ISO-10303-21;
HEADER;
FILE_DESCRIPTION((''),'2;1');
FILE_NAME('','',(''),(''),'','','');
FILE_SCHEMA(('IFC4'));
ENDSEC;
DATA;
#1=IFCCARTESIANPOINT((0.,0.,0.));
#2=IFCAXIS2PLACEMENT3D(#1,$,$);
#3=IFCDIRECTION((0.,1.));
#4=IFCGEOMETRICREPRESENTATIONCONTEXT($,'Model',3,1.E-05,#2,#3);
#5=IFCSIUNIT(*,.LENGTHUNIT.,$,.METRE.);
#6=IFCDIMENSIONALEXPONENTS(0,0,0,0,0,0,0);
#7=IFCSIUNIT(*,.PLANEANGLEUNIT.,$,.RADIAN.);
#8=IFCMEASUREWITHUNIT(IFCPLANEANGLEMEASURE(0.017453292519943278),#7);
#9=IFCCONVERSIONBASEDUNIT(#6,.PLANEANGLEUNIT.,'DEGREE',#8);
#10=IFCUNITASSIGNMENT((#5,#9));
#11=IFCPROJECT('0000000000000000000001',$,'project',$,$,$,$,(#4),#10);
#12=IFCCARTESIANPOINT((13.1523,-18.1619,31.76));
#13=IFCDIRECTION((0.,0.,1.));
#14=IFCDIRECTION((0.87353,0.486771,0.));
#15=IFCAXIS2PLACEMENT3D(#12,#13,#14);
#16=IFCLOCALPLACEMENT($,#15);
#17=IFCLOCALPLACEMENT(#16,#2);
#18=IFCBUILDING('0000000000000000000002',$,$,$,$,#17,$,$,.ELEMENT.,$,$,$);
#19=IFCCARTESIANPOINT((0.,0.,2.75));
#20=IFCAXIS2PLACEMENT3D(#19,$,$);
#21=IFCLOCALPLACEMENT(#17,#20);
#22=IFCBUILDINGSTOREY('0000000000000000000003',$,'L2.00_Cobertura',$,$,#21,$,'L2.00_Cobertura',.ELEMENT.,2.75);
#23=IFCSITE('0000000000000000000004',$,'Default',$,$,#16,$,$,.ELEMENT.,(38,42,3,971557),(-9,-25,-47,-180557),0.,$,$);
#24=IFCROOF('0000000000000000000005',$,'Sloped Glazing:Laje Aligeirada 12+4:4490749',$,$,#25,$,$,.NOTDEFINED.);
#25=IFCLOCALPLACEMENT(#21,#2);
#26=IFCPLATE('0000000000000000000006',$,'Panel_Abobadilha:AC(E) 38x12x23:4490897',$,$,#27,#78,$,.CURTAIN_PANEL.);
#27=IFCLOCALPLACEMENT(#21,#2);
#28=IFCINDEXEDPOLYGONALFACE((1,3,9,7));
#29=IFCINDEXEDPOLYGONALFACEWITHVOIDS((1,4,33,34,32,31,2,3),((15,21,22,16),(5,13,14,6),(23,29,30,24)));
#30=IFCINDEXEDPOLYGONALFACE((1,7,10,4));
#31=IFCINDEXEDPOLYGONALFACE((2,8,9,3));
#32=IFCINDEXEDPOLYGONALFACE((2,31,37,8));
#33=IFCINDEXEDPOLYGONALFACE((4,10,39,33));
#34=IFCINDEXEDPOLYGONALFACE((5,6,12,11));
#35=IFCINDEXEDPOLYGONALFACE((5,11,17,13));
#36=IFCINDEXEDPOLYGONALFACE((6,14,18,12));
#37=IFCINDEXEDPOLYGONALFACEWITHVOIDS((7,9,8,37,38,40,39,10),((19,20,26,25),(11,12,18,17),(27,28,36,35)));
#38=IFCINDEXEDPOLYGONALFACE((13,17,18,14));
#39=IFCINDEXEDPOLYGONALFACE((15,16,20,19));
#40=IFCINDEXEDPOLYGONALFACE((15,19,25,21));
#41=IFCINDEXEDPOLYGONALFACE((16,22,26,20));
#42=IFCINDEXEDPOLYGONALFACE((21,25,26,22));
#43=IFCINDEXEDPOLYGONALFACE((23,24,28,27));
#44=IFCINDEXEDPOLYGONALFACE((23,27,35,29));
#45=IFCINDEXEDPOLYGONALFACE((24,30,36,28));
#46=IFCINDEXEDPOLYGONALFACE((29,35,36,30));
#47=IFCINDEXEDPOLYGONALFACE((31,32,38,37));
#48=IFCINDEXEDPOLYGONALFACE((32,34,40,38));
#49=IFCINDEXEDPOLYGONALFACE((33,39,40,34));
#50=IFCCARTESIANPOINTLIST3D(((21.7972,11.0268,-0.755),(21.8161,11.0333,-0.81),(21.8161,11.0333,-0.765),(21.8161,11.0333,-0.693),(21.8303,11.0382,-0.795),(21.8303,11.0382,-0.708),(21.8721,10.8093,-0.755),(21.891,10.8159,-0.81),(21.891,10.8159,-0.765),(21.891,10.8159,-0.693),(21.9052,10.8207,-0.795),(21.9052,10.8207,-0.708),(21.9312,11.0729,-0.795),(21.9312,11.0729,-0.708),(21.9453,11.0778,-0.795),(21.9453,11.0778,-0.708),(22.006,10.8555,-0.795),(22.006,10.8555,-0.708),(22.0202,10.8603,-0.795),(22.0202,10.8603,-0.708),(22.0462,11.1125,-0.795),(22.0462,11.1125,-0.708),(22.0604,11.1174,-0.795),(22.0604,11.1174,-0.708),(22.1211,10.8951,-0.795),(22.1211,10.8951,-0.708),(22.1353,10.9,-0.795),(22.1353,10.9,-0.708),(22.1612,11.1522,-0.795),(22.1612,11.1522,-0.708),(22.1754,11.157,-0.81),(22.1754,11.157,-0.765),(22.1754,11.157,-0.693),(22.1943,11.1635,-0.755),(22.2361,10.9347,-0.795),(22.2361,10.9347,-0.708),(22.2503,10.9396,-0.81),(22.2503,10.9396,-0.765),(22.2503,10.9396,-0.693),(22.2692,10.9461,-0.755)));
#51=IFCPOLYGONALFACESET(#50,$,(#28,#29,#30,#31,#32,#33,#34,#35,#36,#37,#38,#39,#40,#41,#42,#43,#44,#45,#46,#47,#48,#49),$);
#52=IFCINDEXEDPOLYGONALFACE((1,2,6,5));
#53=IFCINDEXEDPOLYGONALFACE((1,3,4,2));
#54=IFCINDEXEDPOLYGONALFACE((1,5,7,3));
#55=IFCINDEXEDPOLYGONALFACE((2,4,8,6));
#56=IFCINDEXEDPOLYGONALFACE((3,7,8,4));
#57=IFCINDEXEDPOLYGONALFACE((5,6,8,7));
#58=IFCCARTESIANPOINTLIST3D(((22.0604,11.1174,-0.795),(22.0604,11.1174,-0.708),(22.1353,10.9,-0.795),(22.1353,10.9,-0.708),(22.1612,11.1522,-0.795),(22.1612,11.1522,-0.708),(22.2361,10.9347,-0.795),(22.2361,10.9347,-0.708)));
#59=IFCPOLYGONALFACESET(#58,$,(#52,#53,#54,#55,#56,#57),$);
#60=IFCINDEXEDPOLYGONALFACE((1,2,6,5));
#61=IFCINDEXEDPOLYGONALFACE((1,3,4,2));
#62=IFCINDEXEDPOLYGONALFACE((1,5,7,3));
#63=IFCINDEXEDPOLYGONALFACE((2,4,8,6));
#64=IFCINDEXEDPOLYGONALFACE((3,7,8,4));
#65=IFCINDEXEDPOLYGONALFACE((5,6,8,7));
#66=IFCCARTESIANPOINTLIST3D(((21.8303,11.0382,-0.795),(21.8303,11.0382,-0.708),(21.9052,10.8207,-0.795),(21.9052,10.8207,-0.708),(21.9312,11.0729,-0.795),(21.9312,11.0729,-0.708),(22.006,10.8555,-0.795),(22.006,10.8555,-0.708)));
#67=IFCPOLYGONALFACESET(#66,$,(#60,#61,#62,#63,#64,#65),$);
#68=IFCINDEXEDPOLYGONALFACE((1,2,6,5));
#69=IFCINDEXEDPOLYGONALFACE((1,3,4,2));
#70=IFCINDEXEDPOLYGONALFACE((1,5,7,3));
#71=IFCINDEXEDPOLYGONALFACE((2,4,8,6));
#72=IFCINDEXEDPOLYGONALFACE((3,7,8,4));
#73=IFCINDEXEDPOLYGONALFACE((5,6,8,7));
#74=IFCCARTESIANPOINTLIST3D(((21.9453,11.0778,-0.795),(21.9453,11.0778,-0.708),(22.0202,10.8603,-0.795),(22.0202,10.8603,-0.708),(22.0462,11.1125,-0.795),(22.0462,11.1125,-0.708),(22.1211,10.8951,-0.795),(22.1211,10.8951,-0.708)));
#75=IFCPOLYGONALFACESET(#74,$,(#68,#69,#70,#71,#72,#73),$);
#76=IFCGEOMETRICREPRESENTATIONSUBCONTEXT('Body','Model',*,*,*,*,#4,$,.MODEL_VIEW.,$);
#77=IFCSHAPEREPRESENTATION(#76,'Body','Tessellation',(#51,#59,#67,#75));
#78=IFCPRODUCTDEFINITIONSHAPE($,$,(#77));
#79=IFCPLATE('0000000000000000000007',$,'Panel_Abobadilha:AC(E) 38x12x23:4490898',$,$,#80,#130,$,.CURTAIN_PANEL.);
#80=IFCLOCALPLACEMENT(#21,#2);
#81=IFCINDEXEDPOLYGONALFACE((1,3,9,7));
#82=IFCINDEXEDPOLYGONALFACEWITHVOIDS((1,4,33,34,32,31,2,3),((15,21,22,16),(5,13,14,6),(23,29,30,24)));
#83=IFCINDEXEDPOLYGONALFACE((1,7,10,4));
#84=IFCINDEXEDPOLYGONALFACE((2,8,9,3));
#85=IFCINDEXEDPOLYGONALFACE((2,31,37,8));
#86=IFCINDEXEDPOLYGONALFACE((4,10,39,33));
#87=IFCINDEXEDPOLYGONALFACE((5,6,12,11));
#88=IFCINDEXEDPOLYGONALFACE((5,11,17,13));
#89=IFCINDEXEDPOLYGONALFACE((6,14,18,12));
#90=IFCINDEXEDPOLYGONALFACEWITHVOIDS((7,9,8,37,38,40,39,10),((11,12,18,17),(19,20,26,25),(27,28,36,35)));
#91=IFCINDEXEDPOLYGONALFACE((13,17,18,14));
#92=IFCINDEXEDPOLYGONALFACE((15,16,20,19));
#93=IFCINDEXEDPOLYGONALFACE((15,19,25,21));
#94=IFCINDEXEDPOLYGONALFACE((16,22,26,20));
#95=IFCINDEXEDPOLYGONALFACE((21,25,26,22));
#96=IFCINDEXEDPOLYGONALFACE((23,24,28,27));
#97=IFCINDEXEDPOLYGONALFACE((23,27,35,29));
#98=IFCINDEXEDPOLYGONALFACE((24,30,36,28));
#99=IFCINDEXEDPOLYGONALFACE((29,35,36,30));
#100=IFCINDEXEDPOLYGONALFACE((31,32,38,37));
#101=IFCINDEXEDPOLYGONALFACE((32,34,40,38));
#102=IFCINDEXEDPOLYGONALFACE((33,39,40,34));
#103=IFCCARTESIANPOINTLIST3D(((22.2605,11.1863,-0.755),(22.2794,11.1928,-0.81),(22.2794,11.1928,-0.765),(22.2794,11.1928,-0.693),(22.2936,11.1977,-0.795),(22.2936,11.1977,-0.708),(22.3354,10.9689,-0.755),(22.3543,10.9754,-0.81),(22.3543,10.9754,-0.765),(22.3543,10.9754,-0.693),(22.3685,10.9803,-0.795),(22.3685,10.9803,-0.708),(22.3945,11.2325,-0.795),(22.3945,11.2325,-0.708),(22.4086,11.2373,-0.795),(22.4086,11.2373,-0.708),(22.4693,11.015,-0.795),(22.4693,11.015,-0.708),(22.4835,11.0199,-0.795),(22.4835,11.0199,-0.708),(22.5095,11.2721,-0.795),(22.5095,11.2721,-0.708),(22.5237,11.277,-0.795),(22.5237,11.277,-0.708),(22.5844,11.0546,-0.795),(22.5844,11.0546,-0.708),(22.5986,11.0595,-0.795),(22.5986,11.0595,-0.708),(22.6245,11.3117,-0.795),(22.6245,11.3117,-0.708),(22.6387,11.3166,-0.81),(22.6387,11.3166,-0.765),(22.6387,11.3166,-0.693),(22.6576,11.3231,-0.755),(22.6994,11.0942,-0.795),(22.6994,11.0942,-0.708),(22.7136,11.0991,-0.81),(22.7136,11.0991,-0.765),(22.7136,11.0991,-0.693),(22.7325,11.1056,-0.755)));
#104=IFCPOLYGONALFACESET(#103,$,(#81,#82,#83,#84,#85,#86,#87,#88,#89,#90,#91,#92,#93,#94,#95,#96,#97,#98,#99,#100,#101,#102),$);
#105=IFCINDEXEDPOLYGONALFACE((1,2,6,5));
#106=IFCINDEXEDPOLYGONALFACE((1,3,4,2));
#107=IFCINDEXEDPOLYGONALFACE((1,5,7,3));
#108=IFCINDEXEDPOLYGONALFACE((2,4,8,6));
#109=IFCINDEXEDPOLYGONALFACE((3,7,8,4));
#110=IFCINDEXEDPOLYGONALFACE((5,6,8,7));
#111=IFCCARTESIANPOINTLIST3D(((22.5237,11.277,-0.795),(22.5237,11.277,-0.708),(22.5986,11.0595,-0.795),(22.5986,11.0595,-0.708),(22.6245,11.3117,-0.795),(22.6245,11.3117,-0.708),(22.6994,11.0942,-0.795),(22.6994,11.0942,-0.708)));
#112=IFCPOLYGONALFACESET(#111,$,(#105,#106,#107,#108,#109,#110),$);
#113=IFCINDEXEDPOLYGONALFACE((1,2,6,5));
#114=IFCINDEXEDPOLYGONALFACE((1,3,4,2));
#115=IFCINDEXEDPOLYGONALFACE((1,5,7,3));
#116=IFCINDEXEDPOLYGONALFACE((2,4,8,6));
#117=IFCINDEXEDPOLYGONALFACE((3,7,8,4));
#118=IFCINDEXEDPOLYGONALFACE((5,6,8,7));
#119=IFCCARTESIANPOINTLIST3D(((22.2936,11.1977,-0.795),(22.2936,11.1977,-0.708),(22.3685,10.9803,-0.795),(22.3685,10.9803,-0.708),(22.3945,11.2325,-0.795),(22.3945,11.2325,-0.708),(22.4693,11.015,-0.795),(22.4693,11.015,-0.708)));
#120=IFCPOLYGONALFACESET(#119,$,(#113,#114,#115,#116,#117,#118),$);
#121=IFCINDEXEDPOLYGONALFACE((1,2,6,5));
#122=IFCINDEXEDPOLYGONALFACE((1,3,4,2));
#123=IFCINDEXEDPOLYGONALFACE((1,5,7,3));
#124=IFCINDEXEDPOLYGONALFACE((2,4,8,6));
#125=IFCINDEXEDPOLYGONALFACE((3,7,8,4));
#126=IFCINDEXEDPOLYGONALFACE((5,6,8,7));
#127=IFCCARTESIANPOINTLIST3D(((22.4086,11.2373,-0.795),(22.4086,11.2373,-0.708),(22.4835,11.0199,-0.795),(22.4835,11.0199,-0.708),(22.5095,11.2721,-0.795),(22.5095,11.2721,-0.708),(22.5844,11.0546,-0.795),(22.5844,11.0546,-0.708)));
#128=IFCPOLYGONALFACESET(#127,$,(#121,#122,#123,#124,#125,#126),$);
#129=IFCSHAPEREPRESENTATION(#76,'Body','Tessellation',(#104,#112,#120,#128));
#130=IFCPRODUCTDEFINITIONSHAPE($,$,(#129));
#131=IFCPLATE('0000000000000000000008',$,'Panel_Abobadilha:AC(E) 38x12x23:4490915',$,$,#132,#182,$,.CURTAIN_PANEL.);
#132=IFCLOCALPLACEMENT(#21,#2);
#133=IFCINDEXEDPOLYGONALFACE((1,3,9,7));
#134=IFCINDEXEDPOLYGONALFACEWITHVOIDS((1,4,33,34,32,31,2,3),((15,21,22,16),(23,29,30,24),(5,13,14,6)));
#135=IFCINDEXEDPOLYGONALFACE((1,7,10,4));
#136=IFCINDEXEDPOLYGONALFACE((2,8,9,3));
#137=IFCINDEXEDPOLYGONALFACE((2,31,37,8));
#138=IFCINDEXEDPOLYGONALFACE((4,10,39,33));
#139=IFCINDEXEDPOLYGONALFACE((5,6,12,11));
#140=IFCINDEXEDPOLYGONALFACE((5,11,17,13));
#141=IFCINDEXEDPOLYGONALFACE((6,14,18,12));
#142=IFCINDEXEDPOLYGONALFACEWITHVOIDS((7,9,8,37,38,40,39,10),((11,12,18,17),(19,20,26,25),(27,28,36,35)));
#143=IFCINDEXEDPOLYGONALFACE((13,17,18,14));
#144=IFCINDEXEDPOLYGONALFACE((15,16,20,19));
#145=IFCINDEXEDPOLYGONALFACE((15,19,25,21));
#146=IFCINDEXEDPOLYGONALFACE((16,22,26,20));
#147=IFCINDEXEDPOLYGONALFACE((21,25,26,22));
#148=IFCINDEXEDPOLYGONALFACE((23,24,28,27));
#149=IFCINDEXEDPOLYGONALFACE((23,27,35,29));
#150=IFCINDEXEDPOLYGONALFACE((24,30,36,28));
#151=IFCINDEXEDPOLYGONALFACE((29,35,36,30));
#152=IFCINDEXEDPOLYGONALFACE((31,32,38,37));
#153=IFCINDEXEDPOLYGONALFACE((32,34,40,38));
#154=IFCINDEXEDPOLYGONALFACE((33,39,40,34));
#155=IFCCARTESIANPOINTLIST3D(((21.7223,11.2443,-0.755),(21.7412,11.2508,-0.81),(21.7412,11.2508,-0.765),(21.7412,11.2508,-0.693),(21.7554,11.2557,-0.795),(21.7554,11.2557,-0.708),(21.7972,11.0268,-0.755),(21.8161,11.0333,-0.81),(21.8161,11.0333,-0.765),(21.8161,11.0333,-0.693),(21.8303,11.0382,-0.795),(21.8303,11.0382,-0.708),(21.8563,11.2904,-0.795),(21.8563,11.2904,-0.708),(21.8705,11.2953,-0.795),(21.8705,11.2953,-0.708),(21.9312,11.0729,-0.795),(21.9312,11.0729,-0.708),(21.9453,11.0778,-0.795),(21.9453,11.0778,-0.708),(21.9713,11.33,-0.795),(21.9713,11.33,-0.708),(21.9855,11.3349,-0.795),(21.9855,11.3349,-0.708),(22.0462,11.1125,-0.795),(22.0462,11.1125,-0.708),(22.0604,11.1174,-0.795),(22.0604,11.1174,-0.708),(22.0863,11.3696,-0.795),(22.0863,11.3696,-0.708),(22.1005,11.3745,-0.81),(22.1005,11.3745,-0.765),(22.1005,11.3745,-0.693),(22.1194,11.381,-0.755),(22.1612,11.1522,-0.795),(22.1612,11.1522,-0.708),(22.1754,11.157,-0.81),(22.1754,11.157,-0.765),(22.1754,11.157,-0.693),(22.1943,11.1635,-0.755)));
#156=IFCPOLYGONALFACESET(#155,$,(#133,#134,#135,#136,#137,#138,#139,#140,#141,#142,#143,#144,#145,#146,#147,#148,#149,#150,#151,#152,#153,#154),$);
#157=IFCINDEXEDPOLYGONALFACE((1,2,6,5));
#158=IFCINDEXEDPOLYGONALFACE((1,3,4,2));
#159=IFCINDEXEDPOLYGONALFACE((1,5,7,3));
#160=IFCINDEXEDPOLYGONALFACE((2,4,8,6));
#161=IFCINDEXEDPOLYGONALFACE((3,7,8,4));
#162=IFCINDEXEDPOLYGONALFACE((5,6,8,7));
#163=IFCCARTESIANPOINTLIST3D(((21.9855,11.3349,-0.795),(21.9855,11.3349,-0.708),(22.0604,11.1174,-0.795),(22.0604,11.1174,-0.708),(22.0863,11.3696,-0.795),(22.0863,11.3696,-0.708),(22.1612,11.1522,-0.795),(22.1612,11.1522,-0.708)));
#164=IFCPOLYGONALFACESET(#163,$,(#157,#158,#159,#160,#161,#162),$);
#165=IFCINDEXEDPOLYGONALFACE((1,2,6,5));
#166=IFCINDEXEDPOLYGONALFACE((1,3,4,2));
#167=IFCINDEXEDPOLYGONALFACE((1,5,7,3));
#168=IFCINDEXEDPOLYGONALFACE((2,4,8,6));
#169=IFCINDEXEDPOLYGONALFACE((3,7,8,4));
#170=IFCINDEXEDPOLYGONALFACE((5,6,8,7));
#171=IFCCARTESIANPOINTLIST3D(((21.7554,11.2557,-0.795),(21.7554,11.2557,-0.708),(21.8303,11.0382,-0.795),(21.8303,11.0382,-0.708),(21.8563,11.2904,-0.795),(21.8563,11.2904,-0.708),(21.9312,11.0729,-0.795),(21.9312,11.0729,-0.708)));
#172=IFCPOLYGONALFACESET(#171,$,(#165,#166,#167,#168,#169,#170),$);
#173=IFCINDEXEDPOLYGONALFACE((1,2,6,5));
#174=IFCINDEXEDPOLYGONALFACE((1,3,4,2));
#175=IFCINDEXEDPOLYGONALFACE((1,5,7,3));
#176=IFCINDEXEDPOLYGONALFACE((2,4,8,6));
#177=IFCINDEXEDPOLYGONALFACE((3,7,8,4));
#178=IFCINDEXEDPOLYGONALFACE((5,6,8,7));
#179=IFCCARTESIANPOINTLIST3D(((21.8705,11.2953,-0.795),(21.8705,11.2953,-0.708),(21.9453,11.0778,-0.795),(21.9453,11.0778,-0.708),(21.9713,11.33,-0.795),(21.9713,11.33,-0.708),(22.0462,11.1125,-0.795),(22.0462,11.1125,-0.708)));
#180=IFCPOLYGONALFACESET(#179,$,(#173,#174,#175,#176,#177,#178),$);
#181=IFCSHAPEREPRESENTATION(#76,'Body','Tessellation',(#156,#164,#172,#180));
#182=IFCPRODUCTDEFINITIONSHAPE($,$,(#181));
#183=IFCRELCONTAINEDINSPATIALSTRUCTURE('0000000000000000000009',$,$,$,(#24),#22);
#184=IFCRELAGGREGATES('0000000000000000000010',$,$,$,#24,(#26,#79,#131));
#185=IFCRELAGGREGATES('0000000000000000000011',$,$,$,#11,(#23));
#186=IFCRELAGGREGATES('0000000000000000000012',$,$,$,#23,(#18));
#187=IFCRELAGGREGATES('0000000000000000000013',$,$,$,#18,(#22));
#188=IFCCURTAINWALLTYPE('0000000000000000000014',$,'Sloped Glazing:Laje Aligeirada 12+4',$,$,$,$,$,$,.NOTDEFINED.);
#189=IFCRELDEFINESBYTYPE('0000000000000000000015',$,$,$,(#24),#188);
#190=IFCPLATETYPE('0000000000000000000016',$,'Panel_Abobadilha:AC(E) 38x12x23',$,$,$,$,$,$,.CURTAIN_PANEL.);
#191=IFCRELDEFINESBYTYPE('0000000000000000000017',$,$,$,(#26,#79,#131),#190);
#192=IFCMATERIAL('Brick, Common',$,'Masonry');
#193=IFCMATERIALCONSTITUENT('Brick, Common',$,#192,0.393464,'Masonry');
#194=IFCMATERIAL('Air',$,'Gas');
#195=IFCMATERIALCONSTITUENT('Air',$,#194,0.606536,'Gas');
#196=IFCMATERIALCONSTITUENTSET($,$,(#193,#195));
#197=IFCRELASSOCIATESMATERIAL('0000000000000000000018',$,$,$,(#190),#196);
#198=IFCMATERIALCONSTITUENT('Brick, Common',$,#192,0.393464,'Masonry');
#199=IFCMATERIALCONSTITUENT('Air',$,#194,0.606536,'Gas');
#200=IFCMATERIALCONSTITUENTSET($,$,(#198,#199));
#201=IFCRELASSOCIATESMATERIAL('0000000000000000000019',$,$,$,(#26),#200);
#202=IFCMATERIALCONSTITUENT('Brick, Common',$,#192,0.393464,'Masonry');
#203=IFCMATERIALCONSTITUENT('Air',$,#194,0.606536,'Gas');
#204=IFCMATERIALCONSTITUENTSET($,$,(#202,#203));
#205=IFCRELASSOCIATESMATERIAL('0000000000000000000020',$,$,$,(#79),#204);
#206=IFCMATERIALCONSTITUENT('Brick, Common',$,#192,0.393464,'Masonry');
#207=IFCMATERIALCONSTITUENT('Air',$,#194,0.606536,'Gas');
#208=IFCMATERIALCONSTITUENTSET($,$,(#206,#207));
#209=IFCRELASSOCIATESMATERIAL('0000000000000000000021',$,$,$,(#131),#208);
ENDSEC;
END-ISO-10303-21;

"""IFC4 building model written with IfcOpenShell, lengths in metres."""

from ifc_helpers import new_model, entity, si_unit, converted_unit, direction, frame, origin, place, context, subcontext, project, spatial, indexed_curve, outline, extrude, source, transform, mapped, material, constituent, constituent_set, type_object, type_shapes, element, aggregate, save


model = new_model("IFC4")

# Units and contexts
model_context = context("Model", 3, precision=1e-05, world=origin(), true_north=direction((0.0, 1.0)))
body_context = subcontext(model_context, "Body", "Model", "MODEL_VIEW")
ifc_project = project(units=[si_unit("LENGTHUNIT", "METRE"), converted_unit("PLANEANGLEUNIT", "DEGREE", entity("IfcPlaneAngleMeasure", 0.017453292519943278), si_unit("PLANEANGLEUNIT", "RADIAN"), dimensions=[0, 0, 0, 0, 0, 0, 0])], contexts=[model_context])

# Site, building, storey
site_placement = place(None, frame((13.1523, -18.1619, 31.76), z_axis=(0.0, 0.0, 1.0), x_axis=(0.87353, 0.486771, 0.0)))
site = spatial("IfcSite", under=ifc_project, at=site_placement, Name="Default", CompositionType="ELEMENT", RefLatitude=(38, 42, 3, 971557), RefLongitude=(-9, -25, -47, -180557), RefElevation=0.0)
building_placement = place(site_placement, origin())
building = spatial("IfcBuilding", under=site, at=building_placement, CompositionType="ELEMENT")
storey_placement = place(building_placement, frame((0.0, 0.0, 2.75)))
storey = spatial("IfcBuildingStorey", under=building, at=storey_placement, Name="L2.00_Cobertura", LongName="L2.00_Cobertura", CompositionType="ELEMENT", Elevation=2.75)

# Roof
curtain_wall_type = type_object("IfcCurtainWallType", Name="Sloped Glazing:Laje Aligeirada 12+4", PredefinedType="NOTDEFINED")
roof_placement = place(storey_placement, frame((0.0, 0.0, -2.75)))
roof = element("IfcRoof", 1, at=roof_placement, inside=storey, type_object=curtain_wall_type, Name="Sloped Glazing:Laje Aligeirada 12+4:4490749", PredefinedType="NOTDEFINED")

# Plates
ifc_material_1 = material(Name="Brick, Common", Category="Masonry")
ifc_material_2 = material(Name="Air", Category="Gas")
ifc_constituent_1 = constituent(ifc_material_1, Name="Brick, Common", Category="Masonry", fraction=0.393464)
ifc_constituent_2 = constituent(ifc_material_2, Name="Air", Category="Gas", fraction=0.606536)
ifc_constituent_set_1 = constituent_set(constituents=[ifc_constituent_1, ifc_constituent_2])
plate_type_1 = type_object("IfcPlateType", Name="Panel_Abobadilha:AC(E) 38x12x23", PredefinedType="CURTAIN_PANEL", material=ifc_constituent_set_1)
shared_shape_1 = source(origin(), body_context, "Body", "SweptSolid", [
    extrude(outline(indexed_curve([(-0.19, -0.0543), (0.19, -0.0543), (0.19, -0.0093), (0.21, 0.0007), (0.19, 0.0628), (-0.19, 0.0628), (-0.21, 0.0007), (-0.19, -0.0093), (-0.19, -0.0543)], self_intersect=False), holes=[indexed_curve([(-0.0683, 0.0477), (-0.0683, -0.0393), (-0.175, -0.0393), (-0.175, 0.0477), (-0.0683, 0.0477)], self_intersect=False), indexed_curve([(0.0533, 0.0477), (0.0533, -0.0393), (-0.0533, -0.0393), (-0.0533, 0.0477), (0.0533, 0.0477)], self_intersect=False), indexed_curve([(0.175, 0.0477), (0.175, -0.0393), (0.0683, -0.0393), (0.0683, 0.0477), (0.175, 0.0477)], self_intersect=False)]), frame((0.0, 0.0543, 0.0)), (0.0, 0.0, 1.0), 0.23),
    extrude(outline(indexed_curve([(-0.0533, -0.0435), (0.0533, -0.0435), (0.0533, 0.0435), (-0.0533, 0.0435), (-0.0533, -0.0435)], self_intersect=False)), frame((0.1217, 0.0585, 0.0), z_axis=(0.0, 0.0, 1.0), x_axis=(-1.0, 0.0, 0.0)), (0.0, 0.0, 1.0), 0.23),
    extrude(outline(indexed_curve([(-0.0533, -0.0435), (0.0533, -0.0435), (0.0533, 0.0435), (-0.0533, 0.0435), (-0.0533, -0.0435)], self_intersect=False)), frame((-0.1217, 0.0585, 0.0), z_axis=(0.0, 0.0, 1.0), x_axis=(-1.0, 0.0, 0.0)), (0.0, 0.0, 1.0), 0.23),
    extrude(outline(indexed_curve([(-0.0533, -0.0435), (0.0533, -0.0435), (0.0533, 0.0435), (-0.0533, 0.0435), (-0.0533, -0.0435)], self_intersect=False)), frame((0.0, 0.0585, 0.0), z_axis=(0.0, 0.0, 1.0), x_axis=(-1.0, 0.0, 0.0)), (0.0, 0.0, 1.0), 0.23),
])
type_shapes(plate_type_1, [shared_shape_1])
ifc_constituent_3 = constituent(ifc_material_1, Name="Brick, Common", Category="Masonry", fraction=0.393464)
ifc_constituent_4 = constituent(ifc_material_2, Name="Air", Category="Gas", fraction=0.606536)
ifc_constituent_set_2 = constituent_set(constituents=[ifc_constituent_3, ifc_constituent_4])
plate_1_placement = place(roof_placement, frame((21.9958, 11.0952, 1.94), z_axis=(0.325568, -0.945519, 0.0), x_axis=(0.945519, 0.325568, 0.0)))
plate_1 = element("IfcPlate", 2, at=plate_1_placement, type_object=plate_type_1, material=ifc_constituent_set_2, Name="Panel_Abobadilha:AC(E) 38x12x23:4490897", PredefinedType="CURTAIN_PANEL", context=body_context, shape_type="MappedRepresentation", body=[
    mapped(shared_shape_1, transform((0.0, 0.0, 0.0), scale=1.0)),
])
ifc_constituent_5 = constituent(ifc_material_1, Name="Brick, Common", Category="Masonry", fraction=0.393464)
ifc_constituent_6 = constituent(ifc_material_2, Name="Air", Category="Gas", fraction=0.606536)
ifc_constituent_set_3 = constituent_set(constituents=[ifc_constituent_5, ifc_constituent_6])
plate_2_placement = place(roof_placement, frame((22.4591, 11.2547, 1.94), z_axis=(0.325568, -0.945519, 0.0), x_axis=(0.945519, 0.325568, 0.0)))
plate_2 = element("IfcPlate", 3, at=plate_2_placement, type_object=plate_type_1, material=ifc_constituent_set_3, Name="Panel_Abobadilha:AC(E) 38x12x23:4490898", PredefinedType="CURTAIN_PANEL", context=body_context, shape_type="MappedRepresentation", body=[
    mapped(shared_shape_1, transform((0.0, 0.0, 0.0), scale=1.0)),
])
ifc_constituent_7 = constituent(ifc_material_1, Name="Brick, Common", Category="Masonry", fraction=0.393464)
ifc_constituent_8 = constituent(ifc_material_2, Name="Air", Category="Gas", fraction=0.606536)
ifc_constituent_set_4 = constituent_set(constituents=[ifc_constituent_7, ifc_constituent_8])
plate_3_placement = place(roof_placement, frame((21.9209, 11.3126, 1.94), z_axis=(0.325568, -0.945519, 0.0), x_axis=(0.945519, 0.325568, 0.0)))
plate_3 = element("IfcPlate", 4, at=plate_3_placement, type_object=plate_type_1, material=ifc_constituent_set_4, Name="Panel_Abobadilha:AC(E) 38x12x23:4490915", PredefinedType="CURTAIN_PANEL", context=body_context, shape_type="MappedRepresentation", body=[
    mapped(shared_shape_1, transform((0.0, 0.0, 0.0), scale=1.0)),
])
aggregate(roof, [plate_1, plate_2, plate_3])

save(model, "model.ifc")
